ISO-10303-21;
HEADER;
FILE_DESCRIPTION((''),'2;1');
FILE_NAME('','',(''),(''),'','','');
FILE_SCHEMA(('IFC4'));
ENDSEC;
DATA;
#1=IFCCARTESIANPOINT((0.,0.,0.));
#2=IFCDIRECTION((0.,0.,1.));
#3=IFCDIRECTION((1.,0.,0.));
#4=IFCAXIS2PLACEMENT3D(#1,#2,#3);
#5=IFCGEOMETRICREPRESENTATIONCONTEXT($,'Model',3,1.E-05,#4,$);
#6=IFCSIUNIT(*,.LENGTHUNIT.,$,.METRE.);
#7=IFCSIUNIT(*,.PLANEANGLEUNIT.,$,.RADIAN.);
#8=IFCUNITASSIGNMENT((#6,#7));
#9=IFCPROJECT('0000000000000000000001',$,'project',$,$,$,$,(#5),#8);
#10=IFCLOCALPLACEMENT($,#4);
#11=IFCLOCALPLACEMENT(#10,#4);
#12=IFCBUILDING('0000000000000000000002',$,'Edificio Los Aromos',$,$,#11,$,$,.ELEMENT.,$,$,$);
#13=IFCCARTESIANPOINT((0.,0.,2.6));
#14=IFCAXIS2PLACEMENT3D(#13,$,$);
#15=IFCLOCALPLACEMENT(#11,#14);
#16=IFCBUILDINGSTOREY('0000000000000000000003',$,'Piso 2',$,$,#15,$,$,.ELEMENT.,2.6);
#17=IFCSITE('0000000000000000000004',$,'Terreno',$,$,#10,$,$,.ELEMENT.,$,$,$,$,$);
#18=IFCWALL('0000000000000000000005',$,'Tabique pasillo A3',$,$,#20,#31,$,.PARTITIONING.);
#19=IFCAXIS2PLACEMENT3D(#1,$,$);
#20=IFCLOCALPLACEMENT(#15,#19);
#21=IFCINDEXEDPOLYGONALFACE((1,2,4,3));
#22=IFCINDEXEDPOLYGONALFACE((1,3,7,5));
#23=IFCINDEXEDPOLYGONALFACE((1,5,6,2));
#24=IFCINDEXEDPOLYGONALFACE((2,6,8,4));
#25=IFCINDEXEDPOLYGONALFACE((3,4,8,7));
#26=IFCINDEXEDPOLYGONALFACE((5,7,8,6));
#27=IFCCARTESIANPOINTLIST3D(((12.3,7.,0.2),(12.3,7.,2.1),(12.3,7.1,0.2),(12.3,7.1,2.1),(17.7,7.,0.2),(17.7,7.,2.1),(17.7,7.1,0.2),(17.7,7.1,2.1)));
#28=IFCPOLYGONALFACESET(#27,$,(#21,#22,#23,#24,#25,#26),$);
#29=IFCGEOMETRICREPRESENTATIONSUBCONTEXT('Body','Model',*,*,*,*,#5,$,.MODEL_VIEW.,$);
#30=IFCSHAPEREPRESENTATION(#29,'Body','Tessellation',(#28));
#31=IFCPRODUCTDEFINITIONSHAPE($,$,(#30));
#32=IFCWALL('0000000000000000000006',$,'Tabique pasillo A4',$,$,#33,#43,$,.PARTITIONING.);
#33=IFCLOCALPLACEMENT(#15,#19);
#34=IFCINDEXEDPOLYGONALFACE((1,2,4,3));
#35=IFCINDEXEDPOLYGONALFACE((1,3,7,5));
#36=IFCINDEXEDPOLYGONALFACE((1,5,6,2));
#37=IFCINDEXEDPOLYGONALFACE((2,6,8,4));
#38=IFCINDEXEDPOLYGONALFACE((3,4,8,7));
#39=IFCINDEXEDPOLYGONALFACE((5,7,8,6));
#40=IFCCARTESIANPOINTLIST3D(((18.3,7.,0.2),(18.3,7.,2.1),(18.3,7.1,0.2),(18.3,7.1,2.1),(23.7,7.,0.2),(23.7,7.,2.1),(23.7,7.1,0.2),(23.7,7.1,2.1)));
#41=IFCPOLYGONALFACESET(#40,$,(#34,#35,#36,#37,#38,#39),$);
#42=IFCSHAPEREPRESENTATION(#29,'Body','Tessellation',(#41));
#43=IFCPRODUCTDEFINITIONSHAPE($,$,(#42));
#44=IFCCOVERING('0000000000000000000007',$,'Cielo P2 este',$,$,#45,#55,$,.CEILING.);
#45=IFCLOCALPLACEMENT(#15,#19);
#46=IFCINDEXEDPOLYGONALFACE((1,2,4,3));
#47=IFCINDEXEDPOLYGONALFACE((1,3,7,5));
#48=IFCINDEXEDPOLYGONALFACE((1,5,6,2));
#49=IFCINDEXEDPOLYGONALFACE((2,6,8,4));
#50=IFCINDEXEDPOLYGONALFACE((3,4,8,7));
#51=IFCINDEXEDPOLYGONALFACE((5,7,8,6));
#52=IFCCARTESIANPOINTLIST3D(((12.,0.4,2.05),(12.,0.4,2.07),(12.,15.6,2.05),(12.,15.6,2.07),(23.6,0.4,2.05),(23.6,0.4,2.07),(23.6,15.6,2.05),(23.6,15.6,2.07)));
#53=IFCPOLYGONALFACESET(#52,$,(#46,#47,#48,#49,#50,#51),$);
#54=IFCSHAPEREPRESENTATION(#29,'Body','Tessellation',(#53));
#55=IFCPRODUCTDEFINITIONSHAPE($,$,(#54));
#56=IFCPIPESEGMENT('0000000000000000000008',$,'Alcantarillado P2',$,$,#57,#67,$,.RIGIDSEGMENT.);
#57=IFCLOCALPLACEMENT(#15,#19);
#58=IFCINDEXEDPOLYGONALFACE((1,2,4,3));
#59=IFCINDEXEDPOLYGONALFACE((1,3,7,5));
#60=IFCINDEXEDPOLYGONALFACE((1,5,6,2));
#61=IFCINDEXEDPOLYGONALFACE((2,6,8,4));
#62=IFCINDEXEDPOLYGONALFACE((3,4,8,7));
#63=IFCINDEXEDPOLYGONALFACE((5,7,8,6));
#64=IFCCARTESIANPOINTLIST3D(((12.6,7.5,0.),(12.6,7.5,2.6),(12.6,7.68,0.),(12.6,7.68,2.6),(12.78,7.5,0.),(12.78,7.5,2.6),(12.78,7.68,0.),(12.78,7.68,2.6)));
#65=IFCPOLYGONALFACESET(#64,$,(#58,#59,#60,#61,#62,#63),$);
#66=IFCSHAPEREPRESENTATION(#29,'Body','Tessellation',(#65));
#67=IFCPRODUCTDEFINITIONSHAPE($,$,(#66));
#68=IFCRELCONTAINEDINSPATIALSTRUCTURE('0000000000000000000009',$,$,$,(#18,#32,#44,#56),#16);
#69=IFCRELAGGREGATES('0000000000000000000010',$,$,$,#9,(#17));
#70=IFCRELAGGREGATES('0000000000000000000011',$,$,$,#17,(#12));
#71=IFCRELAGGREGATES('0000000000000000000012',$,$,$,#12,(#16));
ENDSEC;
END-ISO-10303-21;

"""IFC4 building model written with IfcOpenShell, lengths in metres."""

from ifc_helpers import new_model, si_unit, frame, frame_2d, origin_with_axes, place, context, subcontext, project, spatial, rectangle, extrude, element, save


model = new_model("IFC4")

# Units and contexts
model_context = context("Model", 3, precision=1e-05, world=origin_with_axes())
body_context = subcontext(model_context, "Body", "Model", "MODEL_VIEW")
ifc_project = project(units=[si_unit("LENGTHUNIT", "METRE"), si_unit("PLANEANGLEUNIT", "RADIAN")], contexts=[model_context])

# Site, building, storey
site_placement = place(None, origin_with_axes())
site = spatial("IfcSite", under=ifc_project, at=site_placement, Name="Terreno", CompositionType="ELEMENT")
building_placement = place(site_placement, origin_with_axes())
building = spatial("IfcBuilding", under=site, at=building_placement, Name="Edificio Los Aromos", CompositionType="ELEMENT")
storey_placement = place(building_placement, frame((0.0, 0.0, 2.6)))
storey = spatial("IfcBuildingStorey", under=building, at=storey_placement, Name="Piso 2", CompositionType="ELEMENT", Elevation=2.6)

# Walls
for number, where, name in (
    (1, (12.3, 7.0, 0.2), "Tabique pasillo A3"),
    (2, (18.3, 7.0, 0.2), "Tabique pasillo A4"),
):
    element("IfcWall", number, at=place(storey_placement, frame(where)), inside=storey, Name=name, PredefinedType="PARTITIONING", context=body_context, shape_type="SweptSolid", body=[
        extrude(rectangle(XDim=5.4, YDim=0.1, at=frame_2d((2.7, 0.05))), origin_with_axes(), (0.0, 0.0, 1.0), 1.9),
    ])

# Covering
covering_placement = place(storey_placement, frame((12.0, 0.4, 2.05)))
element("IfcCovering", 3, at=covering_placement, inside=storey, Name="Cielo P2 este", PredefinedType="CEILING", context=body_context, shape_type="SweptSolid", body=[
    extrude(rectangle(XDim=11.6, YDim=15.2, at=frame_2d((5.8, 7.6))), origin_with_axes(), (0.0, 0.0, 1.0), 0.02),
])

# Pipe segment
pipe_segment_placement = place(storey_placement, frame((12.6, 7.5, 0.0)))
element("IfcPipeSegment", 4, at=pipe_segment_placement, inside=storey, Name="Alcantarillado P2", PredefinedType="RIGIDSEGMENT", context=body_context, shape_type="SweptSolid", body=[
    extrude(rectangle(XDim=0.18, YDim=0.18, at=frame_2d((0.09, 0.09))), origin_with_axes(), (0.0, 0.0, 1.0), 2.6),
])

save(model, "model.ifc")
